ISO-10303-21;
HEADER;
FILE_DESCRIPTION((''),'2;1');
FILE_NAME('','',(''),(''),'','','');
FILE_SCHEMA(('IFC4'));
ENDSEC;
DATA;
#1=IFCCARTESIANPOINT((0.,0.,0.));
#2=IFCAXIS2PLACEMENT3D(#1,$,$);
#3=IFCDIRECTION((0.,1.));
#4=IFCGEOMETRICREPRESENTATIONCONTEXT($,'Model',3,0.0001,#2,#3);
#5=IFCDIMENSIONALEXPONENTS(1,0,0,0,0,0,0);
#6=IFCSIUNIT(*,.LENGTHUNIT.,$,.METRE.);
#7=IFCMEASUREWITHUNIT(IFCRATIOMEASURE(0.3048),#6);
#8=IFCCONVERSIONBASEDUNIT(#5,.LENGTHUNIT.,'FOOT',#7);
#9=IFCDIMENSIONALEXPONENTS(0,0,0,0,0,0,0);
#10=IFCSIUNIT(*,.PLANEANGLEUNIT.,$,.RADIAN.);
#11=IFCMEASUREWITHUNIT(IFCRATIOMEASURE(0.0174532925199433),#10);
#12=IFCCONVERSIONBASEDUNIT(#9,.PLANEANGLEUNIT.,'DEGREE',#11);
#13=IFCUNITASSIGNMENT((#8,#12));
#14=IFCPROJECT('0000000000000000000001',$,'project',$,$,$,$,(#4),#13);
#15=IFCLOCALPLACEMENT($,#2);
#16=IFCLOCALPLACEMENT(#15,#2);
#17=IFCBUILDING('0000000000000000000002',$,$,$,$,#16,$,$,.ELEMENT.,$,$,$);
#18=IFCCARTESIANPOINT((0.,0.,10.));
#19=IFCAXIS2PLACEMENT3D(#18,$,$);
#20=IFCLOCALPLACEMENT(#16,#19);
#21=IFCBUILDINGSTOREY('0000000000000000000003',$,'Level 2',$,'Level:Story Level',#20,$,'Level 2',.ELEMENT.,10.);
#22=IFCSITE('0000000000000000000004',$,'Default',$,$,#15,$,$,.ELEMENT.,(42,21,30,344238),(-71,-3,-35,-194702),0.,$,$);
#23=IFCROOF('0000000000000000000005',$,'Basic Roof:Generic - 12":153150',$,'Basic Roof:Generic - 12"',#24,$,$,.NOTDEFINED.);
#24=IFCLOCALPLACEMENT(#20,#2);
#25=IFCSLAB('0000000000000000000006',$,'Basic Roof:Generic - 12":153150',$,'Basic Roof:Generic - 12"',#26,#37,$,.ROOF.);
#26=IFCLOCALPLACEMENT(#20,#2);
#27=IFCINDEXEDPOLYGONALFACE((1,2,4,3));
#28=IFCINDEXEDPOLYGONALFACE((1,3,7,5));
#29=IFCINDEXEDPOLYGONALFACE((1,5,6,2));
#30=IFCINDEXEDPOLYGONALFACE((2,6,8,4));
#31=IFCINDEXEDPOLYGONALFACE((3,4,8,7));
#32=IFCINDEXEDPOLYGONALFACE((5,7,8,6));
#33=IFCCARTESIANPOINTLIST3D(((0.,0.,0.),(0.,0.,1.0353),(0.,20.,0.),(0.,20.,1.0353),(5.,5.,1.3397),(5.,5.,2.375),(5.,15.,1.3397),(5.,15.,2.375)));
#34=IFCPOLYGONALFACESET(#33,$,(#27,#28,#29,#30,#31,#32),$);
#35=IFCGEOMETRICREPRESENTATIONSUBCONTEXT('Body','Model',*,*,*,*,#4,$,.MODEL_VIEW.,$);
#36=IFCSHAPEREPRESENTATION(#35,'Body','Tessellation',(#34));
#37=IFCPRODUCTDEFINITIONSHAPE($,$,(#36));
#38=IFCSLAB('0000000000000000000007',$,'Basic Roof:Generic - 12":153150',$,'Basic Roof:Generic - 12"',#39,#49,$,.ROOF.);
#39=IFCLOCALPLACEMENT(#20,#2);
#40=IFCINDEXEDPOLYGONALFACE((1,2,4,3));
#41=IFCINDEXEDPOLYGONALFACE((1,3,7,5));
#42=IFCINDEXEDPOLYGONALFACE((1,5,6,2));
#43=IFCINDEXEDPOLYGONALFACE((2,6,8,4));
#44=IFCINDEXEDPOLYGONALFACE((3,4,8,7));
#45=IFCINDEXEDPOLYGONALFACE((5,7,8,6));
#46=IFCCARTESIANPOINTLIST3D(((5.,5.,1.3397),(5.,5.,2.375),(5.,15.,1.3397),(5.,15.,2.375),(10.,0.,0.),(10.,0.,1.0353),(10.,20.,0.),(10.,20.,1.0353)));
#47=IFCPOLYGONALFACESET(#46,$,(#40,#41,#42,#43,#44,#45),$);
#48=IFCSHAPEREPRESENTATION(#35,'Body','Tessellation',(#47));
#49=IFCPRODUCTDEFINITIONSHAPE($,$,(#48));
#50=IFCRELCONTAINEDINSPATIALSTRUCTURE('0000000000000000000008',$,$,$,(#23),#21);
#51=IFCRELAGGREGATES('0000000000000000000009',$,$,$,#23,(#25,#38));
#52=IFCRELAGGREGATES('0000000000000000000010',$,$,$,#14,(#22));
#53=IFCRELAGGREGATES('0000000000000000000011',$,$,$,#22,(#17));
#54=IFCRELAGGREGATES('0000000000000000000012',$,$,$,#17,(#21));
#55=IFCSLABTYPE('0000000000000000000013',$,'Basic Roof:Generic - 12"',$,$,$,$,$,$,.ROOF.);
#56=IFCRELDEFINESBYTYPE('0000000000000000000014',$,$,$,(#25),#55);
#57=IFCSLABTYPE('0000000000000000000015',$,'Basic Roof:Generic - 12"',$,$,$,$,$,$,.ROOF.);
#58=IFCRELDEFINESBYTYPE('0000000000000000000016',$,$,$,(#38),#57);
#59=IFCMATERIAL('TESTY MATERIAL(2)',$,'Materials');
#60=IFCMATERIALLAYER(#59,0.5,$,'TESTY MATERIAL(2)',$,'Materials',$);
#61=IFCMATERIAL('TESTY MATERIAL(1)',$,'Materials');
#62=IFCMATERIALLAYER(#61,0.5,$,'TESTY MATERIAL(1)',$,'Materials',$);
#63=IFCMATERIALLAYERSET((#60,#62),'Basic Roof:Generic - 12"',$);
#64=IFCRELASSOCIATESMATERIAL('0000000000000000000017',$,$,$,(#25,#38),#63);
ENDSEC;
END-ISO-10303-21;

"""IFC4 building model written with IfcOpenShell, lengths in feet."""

from ifc_helpers import new_model, entity, si_unit, converted_unit, direction, frame, origin, place, context, subcontext, project, spatial, polyline, outline, extrude, material, layer, layer_set, type_object, element, aggregate, save


model = new_model("IFC4")

# Units and contexts
model_context = context("Model", 3, precision=0.0001, world=origin(), true_north=direction((0.0, 1.0)))
body_context = subcontext(model_context, "Body", "Model", "MODEL_VIEW")
ifc_project = project(units=[converted_unit("LENGTHUNIT", "FOOT", entity("IfcRatioMeasure", 0.3048), si_unit("LENGTHUNIT", "METRE"), dimensions=[1, 0, 0, 0, 0, 0, 0]), converted_unit("PLANEANGLEUNIT", "DEGREE", entity("IfcRatioMeasure", 0.0174532925199433), si_unit("PLANEANGLEUNIT", "RADIAN"), dimensions=[0, 0, 0, 0, 0, 0, 0])], contexts=[model_context])

# Site, building, storey
site_placement = place(None, origin())
site = spatial("IfcSite", under=ifc_project, at=site_placement, Name="Default", CompositionType="ELEMENT", RefLatitude=(42, 21, 30, 344238), RefLongitude=(-71, -3, -35, -194702), RefElevation=0.0)
building_placement = place(site_placement, origin())
building = spatial("IfcBuilding", under=site, at=building_placement, CompositionType="ELEMENT")
storey_placement = place(building_placement, frame((0.0, 0.0, 10.0)))
storey = spatial("IfcBuildingStorey", under=building, at=storey_placement, Name="Level 2", ObjectType="Level:Story Level", LongName="Level 2", CompositionType="ELEMENT", Elevation=10.0)

# Roof, slabs
roof_placement = place(storey_placement, origin())
roof = element("IfcRoof", 1, at=roof_placement, inside=storey, Name="Basic Roof:Generic - 12\":153150", ObjectType="Basic Roof:Generic - 12\"", PredefinedType="NOTDEFINED")
ifc_material_1 = material(Name="TESTY MATERIAL(2)", Category="Materials")
ifc_layer_1 = layer(ifc_material_1, 0.5, Name="TESTY MATERIAL(2)", Category="Materials")
ifc_material_2 = material(Name="TESTY MATERIAL(1)", Category="Materials")
ifc_layer_2 = layer(ifc_material_2, 0.5, Name="TESTY MATERIAL(1)", Category="Materials")
ifc_layer_set = layer_set([ifc_layer_1, ifc_layer_2], Name="Basic Roof:Generic - 12\"")
slab_type_1 = type_object("IfcSlabType", Name="Basic Roof:Generic - 12\"", PredefinedType="ROOF")
slab_1_placement = place(roof_placement, origin())
slab_1 = element("IfcSlab", 2, at=slab_1_placement, type_object=slab_type_1, material=ifc_layer_set, Name="Basic Roof:Generic - 12\":153150", ObjectType="Basic Roof:Generic - 12\"", PredefinedType="ROOF", context=body_context, shape_type="SweptSolid", body=[
    extrude(outline(polyline([(-2.5882, 10.0), (-2.5882, -10.0), (2.5882, -5.0), (2.5882, 5.0), (-2.5882, 10.0)])), frame((2.5, 10.0, 0.6699), z_axis=(-0.258819, 0.0, 0.965926), x_axis=(0.965926, 0.0, 0.258819)), (0.258819, 0.0, 0.965926), 1.0353),
])
slab_type_2 = type_object("IfcSlabType", Name="Basic Roof:Generic - 12\"", PredefinedType="ROOF")
slab_2_placement = place(roof_placement, origin())
slab_2 = element("IfcSlab", 3, at=slab_2_placement, type_object=slab_type_2, material=ifc_layer_set, Name="Basic Roof:Generic - 12\":153150", ObjectType="Basic Roof:Generic - 12\"", PredefinedType="ROOF", context=body_context, shape_type="SweptSolid", body=[
    extrude(outline(polyline([(2.5882, -10.0), (2.5882, 10.0), (-2.5882, 5.0), (-2.5882, -5.0), (2.5882, -10.0)])), frame((7.5, 10.0, 0.6699), z_axis=(0.258819, 0.0, 0.965926), x_axis=(0.965926, 0.0, -0.258819)), (-0.258819, 0.0, 0.965926), 1.0353),
])
aggregate(roof, [slab_1, slab_2])

save(model, "model.ifc")
